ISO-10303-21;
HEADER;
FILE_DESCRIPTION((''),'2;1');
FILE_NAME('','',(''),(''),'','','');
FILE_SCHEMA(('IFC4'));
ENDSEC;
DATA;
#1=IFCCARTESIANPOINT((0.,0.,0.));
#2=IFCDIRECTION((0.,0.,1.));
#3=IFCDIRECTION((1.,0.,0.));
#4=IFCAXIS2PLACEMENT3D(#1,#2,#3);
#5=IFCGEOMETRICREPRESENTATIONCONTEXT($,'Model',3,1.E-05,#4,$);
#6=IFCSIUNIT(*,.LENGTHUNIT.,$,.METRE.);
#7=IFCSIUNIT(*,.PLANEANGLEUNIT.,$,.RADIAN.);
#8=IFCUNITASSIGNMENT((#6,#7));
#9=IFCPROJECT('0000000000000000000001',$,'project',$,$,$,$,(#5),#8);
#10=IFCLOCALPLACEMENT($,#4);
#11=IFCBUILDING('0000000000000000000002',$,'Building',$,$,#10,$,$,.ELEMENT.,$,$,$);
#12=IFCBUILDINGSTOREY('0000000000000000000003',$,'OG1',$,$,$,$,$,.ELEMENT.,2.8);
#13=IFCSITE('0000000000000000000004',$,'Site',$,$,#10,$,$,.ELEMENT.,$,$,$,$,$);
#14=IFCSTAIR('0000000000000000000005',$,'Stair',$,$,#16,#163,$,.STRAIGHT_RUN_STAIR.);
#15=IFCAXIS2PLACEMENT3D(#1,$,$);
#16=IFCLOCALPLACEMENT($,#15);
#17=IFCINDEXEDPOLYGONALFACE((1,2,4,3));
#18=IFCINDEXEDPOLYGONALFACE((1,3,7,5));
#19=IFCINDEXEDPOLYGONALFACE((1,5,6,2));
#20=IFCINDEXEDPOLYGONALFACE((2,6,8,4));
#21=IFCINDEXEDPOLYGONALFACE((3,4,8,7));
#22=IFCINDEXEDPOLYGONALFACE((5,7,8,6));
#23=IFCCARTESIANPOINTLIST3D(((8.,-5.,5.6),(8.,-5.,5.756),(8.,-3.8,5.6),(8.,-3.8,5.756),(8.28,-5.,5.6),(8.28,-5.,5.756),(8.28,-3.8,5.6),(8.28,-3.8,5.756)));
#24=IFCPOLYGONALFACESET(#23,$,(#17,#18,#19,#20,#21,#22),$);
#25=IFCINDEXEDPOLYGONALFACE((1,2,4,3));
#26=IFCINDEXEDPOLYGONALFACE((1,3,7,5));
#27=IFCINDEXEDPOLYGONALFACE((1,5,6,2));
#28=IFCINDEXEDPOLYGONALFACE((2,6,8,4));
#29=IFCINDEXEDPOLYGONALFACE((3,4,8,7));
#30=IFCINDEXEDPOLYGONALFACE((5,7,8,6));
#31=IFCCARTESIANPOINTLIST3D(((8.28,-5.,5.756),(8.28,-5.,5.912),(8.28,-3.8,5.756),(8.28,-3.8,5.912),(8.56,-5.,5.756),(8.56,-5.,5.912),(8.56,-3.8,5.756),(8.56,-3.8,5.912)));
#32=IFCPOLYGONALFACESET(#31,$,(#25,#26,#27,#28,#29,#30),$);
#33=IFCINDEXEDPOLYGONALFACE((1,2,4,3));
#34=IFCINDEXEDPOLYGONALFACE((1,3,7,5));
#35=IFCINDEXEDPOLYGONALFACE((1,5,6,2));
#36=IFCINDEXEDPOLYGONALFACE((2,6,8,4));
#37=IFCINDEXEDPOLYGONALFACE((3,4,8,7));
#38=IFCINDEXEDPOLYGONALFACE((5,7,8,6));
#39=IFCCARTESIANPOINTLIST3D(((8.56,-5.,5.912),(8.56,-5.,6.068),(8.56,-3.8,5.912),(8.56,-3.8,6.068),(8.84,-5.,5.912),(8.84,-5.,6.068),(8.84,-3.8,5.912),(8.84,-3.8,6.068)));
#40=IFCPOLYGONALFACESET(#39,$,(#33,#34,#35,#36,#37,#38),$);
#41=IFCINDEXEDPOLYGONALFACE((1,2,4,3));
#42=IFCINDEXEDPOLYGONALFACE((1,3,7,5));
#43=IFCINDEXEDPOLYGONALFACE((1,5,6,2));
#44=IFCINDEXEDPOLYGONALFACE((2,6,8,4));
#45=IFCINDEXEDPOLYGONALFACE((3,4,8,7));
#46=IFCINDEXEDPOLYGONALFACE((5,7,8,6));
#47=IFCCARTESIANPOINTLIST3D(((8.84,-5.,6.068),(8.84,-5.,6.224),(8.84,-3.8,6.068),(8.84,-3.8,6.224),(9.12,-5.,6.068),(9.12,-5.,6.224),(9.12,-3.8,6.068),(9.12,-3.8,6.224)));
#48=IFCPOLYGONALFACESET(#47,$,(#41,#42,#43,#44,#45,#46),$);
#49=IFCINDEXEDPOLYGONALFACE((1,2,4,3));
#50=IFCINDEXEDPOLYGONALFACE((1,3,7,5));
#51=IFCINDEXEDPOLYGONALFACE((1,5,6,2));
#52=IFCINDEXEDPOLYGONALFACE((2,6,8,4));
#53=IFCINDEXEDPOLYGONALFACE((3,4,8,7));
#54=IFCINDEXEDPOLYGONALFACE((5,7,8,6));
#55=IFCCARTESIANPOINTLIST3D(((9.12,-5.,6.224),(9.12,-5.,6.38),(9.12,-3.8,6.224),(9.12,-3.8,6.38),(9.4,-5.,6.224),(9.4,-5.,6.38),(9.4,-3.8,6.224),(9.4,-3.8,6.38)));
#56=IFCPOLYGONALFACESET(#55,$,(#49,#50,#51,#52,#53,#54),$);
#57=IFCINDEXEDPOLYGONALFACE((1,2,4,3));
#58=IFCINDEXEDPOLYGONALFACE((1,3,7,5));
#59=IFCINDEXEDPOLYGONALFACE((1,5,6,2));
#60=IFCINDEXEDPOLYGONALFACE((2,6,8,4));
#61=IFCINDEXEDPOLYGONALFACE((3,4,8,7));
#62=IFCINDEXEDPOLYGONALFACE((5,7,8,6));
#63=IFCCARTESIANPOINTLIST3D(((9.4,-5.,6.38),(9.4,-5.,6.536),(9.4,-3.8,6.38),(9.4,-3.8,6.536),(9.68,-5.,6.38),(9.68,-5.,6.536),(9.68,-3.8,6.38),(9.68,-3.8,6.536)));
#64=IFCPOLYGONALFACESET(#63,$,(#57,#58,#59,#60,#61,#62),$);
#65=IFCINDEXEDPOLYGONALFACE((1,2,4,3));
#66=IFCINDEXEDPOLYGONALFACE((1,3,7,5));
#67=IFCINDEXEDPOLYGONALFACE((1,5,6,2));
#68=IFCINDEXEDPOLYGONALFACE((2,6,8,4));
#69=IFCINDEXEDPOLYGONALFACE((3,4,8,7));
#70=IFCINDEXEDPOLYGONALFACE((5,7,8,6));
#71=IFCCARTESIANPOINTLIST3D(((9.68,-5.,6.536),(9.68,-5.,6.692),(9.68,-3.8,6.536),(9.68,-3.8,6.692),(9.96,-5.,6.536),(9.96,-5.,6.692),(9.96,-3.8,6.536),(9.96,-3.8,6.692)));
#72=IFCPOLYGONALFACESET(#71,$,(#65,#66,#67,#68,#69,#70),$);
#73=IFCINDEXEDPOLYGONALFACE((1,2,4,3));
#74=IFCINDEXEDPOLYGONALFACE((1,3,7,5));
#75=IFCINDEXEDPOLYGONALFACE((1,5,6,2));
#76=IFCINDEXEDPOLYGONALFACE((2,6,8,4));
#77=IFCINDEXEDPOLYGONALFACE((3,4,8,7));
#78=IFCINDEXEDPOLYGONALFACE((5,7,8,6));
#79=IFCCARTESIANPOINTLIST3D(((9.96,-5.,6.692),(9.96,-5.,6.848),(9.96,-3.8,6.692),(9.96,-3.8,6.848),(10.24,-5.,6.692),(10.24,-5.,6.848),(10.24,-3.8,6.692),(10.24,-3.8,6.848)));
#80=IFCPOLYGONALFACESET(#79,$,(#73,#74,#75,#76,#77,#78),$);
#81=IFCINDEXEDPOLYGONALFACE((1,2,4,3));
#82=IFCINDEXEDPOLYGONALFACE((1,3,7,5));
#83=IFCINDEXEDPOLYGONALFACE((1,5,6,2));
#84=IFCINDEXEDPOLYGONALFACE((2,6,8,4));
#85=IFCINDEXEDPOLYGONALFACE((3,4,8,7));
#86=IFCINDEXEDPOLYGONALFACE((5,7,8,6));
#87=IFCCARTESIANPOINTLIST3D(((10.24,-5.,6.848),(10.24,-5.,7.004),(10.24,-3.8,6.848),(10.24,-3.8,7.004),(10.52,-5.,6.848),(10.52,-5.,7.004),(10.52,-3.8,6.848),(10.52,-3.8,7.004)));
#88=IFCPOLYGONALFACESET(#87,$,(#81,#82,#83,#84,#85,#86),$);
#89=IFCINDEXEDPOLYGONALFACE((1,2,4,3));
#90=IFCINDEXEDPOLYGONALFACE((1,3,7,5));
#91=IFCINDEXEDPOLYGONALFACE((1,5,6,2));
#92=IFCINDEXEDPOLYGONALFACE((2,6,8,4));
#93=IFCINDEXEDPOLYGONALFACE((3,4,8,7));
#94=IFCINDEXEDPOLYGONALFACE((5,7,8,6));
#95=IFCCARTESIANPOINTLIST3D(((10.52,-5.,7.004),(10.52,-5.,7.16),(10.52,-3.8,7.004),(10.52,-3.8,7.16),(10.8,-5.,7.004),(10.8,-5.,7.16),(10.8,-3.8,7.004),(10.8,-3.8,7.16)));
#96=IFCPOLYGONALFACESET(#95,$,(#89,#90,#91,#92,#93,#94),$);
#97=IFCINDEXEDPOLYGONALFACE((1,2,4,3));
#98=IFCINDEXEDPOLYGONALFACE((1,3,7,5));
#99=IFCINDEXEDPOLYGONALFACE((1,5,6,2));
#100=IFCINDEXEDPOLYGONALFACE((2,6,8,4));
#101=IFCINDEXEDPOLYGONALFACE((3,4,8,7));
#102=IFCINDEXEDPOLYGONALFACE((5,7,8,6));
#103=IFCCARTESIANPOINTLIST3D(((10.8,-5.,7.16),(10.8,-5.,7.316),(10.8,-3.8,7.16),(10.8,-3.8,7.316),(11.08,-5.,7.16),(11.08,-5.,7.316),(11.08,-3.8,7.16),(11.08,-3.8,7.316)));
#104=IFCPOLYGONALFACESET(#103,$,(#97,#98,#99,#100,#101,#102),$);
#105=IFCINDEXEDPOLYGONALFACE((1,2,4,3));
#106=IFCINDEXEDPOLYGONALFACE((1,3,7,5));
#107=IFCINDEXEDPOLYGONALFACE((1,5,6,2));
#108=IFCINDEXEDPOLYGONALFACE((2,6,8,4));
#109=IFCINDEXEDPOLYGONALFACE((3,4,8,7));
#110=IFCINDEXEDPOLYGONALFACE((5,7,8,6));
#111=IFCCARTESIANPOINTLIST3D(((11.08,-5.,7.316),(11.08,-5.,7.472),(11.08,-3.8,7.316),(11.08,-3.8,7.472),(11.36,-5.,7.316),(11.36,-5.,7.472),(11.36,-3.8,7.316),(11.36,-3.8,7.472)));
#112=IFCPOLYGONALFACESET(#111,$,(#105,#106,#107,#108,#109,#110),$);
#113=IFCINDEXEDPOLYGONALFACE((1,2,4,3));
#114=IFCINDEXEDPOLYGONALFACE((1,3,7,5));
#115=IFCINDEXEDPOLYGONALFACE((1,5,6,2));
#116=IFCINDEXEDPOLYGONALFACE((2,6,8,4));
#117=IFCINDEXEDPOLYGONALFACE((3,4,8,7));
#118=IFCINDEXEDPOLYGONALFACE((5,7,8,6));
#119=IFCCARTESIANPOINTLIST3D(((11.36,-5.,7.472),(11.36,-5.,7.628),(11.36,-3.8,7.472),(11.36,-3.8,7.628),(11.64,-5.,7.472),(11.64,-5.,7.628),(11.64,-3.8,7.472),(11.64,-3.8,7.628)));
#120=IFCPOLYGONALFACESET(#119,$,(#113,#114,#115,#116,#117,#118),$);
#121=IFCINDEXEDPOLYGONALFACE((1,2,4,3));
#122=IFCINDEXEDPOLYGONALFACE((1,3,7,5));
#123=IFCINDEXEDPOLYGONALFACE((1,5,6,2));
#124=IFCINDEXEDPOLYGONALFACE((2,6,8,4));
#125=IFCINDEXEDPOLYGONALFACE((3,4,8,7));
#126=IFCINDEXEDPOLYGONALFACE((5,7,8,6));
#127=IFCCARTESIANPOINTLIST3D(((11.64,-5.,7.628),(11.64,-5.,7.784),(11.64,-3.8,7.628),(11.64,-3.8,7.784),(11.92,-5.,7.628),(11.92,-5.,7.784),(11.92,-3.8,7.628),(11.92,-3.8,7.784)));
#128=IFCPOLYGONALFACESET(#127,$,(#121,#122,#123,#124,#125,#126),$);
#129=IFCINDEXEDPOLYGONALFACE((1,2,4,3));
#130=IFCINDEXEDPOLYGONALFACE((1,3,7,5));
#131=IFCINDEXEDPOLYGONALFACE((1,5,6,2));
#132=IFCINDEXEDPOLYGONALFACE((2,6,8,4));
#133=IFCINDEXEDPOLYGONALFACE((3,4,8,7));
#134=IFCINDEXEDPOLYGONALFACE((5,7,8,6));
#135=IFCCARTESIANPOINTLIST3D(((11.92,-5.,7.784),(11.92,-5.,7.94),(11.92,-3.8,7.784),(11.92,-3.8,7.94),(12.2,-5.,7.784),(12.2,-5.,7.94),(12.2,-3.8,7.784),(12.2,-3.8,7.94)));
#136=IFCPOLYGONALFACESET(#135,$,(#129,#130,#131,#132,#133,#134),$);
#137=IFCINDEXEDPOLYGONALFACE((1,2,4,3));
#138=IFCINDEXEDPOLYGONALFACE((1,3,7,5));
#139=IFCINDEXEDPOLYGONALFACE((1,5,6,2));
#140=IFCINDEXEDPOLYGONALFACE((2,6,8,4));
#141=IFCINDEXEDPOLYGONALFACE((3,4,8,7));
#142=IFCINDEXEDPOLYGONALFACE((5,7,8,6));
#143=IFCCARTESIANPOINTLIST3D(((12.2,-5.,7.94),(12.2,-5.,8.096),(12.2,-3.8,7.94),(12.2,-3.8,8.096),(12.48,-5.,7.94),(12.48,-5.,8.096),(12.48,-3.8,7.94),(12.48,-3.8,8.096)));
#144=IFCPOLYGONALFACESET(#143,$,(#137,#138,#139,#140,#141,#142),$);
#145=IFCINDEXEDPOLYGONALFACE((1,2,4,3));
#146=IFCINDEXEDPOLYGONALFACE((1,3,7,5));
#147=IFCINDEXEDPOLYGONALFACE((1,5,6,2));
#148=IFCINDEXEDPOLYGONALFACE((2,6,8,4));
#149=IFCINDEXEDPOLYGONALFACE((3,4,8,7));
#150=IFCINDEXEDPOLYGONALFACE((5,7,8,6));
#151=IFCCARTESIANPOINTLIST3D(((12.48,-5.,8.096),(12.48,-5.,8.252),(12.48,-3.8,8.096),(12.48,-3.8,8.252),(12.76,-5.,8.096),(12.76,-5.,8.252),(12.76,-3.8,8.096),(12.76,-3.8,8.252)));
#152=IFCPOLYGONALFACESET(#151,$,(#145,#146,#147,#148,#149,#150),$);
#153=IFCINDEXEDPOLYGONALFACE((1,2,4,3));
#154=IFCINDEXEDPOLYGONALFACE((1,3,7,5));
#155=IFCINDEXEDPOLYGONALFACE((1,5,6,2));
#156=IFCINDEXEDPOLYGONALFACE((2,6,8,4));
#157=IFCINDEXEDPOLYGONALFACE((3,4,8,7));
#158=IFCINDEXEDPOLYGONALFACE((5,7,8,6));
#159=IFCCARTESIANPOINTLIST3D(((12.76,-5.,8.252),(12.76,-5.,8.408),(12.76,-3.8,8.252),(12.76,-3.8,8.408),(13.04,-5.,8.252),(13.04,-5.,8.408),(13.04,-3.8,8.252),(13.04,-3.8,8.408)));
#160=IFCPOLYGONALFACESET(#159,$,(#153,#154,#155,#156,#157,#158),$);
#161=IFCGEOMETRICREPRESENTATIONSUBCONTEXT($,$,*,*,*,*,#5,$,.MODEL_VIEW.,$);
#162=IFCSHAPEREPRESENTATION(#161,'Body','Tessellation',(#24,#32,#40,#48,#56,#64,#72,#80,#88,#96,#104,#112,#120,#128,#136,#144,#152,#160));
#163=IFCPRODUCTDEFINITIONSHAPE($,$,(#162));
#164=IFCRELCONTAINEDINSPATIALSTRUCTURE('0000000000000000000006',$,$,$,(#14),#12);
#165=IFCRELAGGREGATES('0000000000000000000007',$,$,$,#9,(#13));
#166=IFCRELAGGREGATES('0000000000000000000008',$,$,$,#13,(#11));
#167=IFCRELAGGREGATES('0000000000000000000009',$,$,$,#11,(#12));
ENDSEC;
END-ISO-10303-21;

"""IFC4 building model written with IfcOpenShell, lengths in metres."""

from ifc_helpers import new_model, si_unit, frame, frame_2d, origin, origin_with_axes, place, context, subcontext, project, spatial, rectangle, extrude, element, save


model = new_model("IFC4")

# Units and contexts
model_context = context("Model", 3, precision=1e-05, world=origin_with_axes())
sub_context = subcontext(model_context, None, None, "MODEL_VIEW")
ifc_project = project(units=[si_unit("LENGTHUNIT", "METRE"), si_unit("PLANEANGLEUNIT", "RADIAN")], contexts=[model_context])

# Site, building, storey
placement_1 = place(None, origin_with_axes())
site = spatial("IfcSite", under=ifc_project, at=placement_1, Name="Site", CompositionType="ELEMENT")
building = spatial("IfcBuilding", under=site, at=placement_1, Name="Building", CompositionType="ELEMENT")
storey = spatial("IfcBuildingStorey", under=building, Name="OG1", CompositionType="ELEMENT", Elevation=2.8)

# Stair
placement_2 = place(None, origin_with_axes())
placement_3 = place(placement_2, frame((0.0, 0.0, 2.8)))
stair_placement = place(placement_3, frame((8.0, -5.0, 2.8)))
element("IfcStair", 1, at=stair_placement, inside=storey, Name="Stair", PredefinedType="STRAIGHT_RUN_STAIR", context=sub_context, shape_type="SolidModel", body=[
    extrude(rectangle(XDim=0.28, YDim=1.2, at=frame_2d((0.14, 0.6))), origin(), (0.0, 0.0, 1.0), 0.156),
    extrude(rectangle(XDim=0.28, YDim=1.2, at=frame_2d((0.14, 0.6))), frame((0.28, 0.0, 0.156)), (0.0, 0.0, 1.0), 0.156),
    extrude(rectangle(XDim=0.28, YDim=1.2, at=frame_2d((0.14, 0.6))), frame((0.56, 0.0, 0.312)), (0.0, 0.0, 1.0), 0.156),
    extrude(rectangle(XDim=0.28, YDim=1.2, at=frame_2d((0.14, 0.6))), frame((0.84, 0.0, 0.468)), (0.0, 0.0, 1.0), 0.156),
    extrude(rectangle(XDim=0.28, YDim=1.2, at=frame_2d((0.14, 0.6))), frame((1.12, 0.0, 0.624)), (0.0, 0.0, 1.0), 0.156),
    extrude(rectangle(XDim=0.28, YDim=1.2, at=frame_2d((0.14, 0.6))), frame((1.4, 0.0, 0.78)), (0.0, 0.0, 1.0), 0.156),
    extrude(rectangle(XDim=0.28, YDim=1.2, at=frame_2d((0.14, 0.6))), frame((1.68, 0.0, 0.936)), (0.0, 0.0, 1.0), 0.156),
    extrude(rectangle(XDim=0.28, YDim=1.2, at=frame_2d((0.14, 0.6))), frame((1.96, 0.0, 1.092)), (0.0, 0.0, 1.0), 0.156),
    extrude(rectangle(XDim=0.28, YDim=1.2, at=frame_2d((0.14, 0.6))), frame((2.24, 0.0, 1.248)), (0.0, 0.0, 1.0), 0.156),
    extrude(rectangle(XDim=0.28, YDim=1.2, at=frame_2d((0.14, 0.6))), frame((2.52, 0.0, 1.404)), (0.0, 0.0, 1.0), 0.156),
    extrude(rectangle(XDim=0.28, YDim=1.2, at=frame_2d((0.14, 0.6))), frame((2.8, 0.0, 1.56)), (0.0, 0.0, 1.0), 0.156),
    extrude(rectangle(XDim=0.28, YDim=1.2, at=frame_2d((0.14, 0.6))), frame((3.08, 0.0, 1.716)), (0.0, 0.0, 1.0), 0.156),
    extrude(rectangle(XDim=0.28, YDim=1.2, at=frame_2d((0.14, 0.6))), frame((3.36, 0.0, 1.872)), (0.0, 0.0, 1.0), 0.156),
    extrude(rectangle(XDim=0.28, YDim=1.2, at=frame_2d((0.14, 0.6))), frame((3.64, 0.0, 2.028)), (0.0, 0.0, 1.0), 0.156),
    extrude(rectangle(XDim=0.28, YDim=1.2, at=frame_2d((0.14, 0.6))), frame((3.92, 0.0, 2.184)), (0.0, 0.0, 1.0), 0.156),
    extrude(rectangle(XDim=0.28, YDim=1.2, at=frame_2d((0.14, 0.6))), frame((4.2, 0.0, 2.34)), (0.0, 0.0, 1.0), 0.156),
    extrude(rectangle(XDim=0.28, YDim=1.2, at=frame_2d((0.14, 0.6))), frame((4.48, 0.0, 2.496)), (0.0, 0.0, 1.0), 0.156),
    extrude(rectangle(XDim=0.28, YDim=1.2, at=frame_2d((0.14, 0.6))), frame((4.76, 0.0, 2.652)), (0.0, 0.0, 1.0), 0.156),
])

save(model, "model.ifc")
